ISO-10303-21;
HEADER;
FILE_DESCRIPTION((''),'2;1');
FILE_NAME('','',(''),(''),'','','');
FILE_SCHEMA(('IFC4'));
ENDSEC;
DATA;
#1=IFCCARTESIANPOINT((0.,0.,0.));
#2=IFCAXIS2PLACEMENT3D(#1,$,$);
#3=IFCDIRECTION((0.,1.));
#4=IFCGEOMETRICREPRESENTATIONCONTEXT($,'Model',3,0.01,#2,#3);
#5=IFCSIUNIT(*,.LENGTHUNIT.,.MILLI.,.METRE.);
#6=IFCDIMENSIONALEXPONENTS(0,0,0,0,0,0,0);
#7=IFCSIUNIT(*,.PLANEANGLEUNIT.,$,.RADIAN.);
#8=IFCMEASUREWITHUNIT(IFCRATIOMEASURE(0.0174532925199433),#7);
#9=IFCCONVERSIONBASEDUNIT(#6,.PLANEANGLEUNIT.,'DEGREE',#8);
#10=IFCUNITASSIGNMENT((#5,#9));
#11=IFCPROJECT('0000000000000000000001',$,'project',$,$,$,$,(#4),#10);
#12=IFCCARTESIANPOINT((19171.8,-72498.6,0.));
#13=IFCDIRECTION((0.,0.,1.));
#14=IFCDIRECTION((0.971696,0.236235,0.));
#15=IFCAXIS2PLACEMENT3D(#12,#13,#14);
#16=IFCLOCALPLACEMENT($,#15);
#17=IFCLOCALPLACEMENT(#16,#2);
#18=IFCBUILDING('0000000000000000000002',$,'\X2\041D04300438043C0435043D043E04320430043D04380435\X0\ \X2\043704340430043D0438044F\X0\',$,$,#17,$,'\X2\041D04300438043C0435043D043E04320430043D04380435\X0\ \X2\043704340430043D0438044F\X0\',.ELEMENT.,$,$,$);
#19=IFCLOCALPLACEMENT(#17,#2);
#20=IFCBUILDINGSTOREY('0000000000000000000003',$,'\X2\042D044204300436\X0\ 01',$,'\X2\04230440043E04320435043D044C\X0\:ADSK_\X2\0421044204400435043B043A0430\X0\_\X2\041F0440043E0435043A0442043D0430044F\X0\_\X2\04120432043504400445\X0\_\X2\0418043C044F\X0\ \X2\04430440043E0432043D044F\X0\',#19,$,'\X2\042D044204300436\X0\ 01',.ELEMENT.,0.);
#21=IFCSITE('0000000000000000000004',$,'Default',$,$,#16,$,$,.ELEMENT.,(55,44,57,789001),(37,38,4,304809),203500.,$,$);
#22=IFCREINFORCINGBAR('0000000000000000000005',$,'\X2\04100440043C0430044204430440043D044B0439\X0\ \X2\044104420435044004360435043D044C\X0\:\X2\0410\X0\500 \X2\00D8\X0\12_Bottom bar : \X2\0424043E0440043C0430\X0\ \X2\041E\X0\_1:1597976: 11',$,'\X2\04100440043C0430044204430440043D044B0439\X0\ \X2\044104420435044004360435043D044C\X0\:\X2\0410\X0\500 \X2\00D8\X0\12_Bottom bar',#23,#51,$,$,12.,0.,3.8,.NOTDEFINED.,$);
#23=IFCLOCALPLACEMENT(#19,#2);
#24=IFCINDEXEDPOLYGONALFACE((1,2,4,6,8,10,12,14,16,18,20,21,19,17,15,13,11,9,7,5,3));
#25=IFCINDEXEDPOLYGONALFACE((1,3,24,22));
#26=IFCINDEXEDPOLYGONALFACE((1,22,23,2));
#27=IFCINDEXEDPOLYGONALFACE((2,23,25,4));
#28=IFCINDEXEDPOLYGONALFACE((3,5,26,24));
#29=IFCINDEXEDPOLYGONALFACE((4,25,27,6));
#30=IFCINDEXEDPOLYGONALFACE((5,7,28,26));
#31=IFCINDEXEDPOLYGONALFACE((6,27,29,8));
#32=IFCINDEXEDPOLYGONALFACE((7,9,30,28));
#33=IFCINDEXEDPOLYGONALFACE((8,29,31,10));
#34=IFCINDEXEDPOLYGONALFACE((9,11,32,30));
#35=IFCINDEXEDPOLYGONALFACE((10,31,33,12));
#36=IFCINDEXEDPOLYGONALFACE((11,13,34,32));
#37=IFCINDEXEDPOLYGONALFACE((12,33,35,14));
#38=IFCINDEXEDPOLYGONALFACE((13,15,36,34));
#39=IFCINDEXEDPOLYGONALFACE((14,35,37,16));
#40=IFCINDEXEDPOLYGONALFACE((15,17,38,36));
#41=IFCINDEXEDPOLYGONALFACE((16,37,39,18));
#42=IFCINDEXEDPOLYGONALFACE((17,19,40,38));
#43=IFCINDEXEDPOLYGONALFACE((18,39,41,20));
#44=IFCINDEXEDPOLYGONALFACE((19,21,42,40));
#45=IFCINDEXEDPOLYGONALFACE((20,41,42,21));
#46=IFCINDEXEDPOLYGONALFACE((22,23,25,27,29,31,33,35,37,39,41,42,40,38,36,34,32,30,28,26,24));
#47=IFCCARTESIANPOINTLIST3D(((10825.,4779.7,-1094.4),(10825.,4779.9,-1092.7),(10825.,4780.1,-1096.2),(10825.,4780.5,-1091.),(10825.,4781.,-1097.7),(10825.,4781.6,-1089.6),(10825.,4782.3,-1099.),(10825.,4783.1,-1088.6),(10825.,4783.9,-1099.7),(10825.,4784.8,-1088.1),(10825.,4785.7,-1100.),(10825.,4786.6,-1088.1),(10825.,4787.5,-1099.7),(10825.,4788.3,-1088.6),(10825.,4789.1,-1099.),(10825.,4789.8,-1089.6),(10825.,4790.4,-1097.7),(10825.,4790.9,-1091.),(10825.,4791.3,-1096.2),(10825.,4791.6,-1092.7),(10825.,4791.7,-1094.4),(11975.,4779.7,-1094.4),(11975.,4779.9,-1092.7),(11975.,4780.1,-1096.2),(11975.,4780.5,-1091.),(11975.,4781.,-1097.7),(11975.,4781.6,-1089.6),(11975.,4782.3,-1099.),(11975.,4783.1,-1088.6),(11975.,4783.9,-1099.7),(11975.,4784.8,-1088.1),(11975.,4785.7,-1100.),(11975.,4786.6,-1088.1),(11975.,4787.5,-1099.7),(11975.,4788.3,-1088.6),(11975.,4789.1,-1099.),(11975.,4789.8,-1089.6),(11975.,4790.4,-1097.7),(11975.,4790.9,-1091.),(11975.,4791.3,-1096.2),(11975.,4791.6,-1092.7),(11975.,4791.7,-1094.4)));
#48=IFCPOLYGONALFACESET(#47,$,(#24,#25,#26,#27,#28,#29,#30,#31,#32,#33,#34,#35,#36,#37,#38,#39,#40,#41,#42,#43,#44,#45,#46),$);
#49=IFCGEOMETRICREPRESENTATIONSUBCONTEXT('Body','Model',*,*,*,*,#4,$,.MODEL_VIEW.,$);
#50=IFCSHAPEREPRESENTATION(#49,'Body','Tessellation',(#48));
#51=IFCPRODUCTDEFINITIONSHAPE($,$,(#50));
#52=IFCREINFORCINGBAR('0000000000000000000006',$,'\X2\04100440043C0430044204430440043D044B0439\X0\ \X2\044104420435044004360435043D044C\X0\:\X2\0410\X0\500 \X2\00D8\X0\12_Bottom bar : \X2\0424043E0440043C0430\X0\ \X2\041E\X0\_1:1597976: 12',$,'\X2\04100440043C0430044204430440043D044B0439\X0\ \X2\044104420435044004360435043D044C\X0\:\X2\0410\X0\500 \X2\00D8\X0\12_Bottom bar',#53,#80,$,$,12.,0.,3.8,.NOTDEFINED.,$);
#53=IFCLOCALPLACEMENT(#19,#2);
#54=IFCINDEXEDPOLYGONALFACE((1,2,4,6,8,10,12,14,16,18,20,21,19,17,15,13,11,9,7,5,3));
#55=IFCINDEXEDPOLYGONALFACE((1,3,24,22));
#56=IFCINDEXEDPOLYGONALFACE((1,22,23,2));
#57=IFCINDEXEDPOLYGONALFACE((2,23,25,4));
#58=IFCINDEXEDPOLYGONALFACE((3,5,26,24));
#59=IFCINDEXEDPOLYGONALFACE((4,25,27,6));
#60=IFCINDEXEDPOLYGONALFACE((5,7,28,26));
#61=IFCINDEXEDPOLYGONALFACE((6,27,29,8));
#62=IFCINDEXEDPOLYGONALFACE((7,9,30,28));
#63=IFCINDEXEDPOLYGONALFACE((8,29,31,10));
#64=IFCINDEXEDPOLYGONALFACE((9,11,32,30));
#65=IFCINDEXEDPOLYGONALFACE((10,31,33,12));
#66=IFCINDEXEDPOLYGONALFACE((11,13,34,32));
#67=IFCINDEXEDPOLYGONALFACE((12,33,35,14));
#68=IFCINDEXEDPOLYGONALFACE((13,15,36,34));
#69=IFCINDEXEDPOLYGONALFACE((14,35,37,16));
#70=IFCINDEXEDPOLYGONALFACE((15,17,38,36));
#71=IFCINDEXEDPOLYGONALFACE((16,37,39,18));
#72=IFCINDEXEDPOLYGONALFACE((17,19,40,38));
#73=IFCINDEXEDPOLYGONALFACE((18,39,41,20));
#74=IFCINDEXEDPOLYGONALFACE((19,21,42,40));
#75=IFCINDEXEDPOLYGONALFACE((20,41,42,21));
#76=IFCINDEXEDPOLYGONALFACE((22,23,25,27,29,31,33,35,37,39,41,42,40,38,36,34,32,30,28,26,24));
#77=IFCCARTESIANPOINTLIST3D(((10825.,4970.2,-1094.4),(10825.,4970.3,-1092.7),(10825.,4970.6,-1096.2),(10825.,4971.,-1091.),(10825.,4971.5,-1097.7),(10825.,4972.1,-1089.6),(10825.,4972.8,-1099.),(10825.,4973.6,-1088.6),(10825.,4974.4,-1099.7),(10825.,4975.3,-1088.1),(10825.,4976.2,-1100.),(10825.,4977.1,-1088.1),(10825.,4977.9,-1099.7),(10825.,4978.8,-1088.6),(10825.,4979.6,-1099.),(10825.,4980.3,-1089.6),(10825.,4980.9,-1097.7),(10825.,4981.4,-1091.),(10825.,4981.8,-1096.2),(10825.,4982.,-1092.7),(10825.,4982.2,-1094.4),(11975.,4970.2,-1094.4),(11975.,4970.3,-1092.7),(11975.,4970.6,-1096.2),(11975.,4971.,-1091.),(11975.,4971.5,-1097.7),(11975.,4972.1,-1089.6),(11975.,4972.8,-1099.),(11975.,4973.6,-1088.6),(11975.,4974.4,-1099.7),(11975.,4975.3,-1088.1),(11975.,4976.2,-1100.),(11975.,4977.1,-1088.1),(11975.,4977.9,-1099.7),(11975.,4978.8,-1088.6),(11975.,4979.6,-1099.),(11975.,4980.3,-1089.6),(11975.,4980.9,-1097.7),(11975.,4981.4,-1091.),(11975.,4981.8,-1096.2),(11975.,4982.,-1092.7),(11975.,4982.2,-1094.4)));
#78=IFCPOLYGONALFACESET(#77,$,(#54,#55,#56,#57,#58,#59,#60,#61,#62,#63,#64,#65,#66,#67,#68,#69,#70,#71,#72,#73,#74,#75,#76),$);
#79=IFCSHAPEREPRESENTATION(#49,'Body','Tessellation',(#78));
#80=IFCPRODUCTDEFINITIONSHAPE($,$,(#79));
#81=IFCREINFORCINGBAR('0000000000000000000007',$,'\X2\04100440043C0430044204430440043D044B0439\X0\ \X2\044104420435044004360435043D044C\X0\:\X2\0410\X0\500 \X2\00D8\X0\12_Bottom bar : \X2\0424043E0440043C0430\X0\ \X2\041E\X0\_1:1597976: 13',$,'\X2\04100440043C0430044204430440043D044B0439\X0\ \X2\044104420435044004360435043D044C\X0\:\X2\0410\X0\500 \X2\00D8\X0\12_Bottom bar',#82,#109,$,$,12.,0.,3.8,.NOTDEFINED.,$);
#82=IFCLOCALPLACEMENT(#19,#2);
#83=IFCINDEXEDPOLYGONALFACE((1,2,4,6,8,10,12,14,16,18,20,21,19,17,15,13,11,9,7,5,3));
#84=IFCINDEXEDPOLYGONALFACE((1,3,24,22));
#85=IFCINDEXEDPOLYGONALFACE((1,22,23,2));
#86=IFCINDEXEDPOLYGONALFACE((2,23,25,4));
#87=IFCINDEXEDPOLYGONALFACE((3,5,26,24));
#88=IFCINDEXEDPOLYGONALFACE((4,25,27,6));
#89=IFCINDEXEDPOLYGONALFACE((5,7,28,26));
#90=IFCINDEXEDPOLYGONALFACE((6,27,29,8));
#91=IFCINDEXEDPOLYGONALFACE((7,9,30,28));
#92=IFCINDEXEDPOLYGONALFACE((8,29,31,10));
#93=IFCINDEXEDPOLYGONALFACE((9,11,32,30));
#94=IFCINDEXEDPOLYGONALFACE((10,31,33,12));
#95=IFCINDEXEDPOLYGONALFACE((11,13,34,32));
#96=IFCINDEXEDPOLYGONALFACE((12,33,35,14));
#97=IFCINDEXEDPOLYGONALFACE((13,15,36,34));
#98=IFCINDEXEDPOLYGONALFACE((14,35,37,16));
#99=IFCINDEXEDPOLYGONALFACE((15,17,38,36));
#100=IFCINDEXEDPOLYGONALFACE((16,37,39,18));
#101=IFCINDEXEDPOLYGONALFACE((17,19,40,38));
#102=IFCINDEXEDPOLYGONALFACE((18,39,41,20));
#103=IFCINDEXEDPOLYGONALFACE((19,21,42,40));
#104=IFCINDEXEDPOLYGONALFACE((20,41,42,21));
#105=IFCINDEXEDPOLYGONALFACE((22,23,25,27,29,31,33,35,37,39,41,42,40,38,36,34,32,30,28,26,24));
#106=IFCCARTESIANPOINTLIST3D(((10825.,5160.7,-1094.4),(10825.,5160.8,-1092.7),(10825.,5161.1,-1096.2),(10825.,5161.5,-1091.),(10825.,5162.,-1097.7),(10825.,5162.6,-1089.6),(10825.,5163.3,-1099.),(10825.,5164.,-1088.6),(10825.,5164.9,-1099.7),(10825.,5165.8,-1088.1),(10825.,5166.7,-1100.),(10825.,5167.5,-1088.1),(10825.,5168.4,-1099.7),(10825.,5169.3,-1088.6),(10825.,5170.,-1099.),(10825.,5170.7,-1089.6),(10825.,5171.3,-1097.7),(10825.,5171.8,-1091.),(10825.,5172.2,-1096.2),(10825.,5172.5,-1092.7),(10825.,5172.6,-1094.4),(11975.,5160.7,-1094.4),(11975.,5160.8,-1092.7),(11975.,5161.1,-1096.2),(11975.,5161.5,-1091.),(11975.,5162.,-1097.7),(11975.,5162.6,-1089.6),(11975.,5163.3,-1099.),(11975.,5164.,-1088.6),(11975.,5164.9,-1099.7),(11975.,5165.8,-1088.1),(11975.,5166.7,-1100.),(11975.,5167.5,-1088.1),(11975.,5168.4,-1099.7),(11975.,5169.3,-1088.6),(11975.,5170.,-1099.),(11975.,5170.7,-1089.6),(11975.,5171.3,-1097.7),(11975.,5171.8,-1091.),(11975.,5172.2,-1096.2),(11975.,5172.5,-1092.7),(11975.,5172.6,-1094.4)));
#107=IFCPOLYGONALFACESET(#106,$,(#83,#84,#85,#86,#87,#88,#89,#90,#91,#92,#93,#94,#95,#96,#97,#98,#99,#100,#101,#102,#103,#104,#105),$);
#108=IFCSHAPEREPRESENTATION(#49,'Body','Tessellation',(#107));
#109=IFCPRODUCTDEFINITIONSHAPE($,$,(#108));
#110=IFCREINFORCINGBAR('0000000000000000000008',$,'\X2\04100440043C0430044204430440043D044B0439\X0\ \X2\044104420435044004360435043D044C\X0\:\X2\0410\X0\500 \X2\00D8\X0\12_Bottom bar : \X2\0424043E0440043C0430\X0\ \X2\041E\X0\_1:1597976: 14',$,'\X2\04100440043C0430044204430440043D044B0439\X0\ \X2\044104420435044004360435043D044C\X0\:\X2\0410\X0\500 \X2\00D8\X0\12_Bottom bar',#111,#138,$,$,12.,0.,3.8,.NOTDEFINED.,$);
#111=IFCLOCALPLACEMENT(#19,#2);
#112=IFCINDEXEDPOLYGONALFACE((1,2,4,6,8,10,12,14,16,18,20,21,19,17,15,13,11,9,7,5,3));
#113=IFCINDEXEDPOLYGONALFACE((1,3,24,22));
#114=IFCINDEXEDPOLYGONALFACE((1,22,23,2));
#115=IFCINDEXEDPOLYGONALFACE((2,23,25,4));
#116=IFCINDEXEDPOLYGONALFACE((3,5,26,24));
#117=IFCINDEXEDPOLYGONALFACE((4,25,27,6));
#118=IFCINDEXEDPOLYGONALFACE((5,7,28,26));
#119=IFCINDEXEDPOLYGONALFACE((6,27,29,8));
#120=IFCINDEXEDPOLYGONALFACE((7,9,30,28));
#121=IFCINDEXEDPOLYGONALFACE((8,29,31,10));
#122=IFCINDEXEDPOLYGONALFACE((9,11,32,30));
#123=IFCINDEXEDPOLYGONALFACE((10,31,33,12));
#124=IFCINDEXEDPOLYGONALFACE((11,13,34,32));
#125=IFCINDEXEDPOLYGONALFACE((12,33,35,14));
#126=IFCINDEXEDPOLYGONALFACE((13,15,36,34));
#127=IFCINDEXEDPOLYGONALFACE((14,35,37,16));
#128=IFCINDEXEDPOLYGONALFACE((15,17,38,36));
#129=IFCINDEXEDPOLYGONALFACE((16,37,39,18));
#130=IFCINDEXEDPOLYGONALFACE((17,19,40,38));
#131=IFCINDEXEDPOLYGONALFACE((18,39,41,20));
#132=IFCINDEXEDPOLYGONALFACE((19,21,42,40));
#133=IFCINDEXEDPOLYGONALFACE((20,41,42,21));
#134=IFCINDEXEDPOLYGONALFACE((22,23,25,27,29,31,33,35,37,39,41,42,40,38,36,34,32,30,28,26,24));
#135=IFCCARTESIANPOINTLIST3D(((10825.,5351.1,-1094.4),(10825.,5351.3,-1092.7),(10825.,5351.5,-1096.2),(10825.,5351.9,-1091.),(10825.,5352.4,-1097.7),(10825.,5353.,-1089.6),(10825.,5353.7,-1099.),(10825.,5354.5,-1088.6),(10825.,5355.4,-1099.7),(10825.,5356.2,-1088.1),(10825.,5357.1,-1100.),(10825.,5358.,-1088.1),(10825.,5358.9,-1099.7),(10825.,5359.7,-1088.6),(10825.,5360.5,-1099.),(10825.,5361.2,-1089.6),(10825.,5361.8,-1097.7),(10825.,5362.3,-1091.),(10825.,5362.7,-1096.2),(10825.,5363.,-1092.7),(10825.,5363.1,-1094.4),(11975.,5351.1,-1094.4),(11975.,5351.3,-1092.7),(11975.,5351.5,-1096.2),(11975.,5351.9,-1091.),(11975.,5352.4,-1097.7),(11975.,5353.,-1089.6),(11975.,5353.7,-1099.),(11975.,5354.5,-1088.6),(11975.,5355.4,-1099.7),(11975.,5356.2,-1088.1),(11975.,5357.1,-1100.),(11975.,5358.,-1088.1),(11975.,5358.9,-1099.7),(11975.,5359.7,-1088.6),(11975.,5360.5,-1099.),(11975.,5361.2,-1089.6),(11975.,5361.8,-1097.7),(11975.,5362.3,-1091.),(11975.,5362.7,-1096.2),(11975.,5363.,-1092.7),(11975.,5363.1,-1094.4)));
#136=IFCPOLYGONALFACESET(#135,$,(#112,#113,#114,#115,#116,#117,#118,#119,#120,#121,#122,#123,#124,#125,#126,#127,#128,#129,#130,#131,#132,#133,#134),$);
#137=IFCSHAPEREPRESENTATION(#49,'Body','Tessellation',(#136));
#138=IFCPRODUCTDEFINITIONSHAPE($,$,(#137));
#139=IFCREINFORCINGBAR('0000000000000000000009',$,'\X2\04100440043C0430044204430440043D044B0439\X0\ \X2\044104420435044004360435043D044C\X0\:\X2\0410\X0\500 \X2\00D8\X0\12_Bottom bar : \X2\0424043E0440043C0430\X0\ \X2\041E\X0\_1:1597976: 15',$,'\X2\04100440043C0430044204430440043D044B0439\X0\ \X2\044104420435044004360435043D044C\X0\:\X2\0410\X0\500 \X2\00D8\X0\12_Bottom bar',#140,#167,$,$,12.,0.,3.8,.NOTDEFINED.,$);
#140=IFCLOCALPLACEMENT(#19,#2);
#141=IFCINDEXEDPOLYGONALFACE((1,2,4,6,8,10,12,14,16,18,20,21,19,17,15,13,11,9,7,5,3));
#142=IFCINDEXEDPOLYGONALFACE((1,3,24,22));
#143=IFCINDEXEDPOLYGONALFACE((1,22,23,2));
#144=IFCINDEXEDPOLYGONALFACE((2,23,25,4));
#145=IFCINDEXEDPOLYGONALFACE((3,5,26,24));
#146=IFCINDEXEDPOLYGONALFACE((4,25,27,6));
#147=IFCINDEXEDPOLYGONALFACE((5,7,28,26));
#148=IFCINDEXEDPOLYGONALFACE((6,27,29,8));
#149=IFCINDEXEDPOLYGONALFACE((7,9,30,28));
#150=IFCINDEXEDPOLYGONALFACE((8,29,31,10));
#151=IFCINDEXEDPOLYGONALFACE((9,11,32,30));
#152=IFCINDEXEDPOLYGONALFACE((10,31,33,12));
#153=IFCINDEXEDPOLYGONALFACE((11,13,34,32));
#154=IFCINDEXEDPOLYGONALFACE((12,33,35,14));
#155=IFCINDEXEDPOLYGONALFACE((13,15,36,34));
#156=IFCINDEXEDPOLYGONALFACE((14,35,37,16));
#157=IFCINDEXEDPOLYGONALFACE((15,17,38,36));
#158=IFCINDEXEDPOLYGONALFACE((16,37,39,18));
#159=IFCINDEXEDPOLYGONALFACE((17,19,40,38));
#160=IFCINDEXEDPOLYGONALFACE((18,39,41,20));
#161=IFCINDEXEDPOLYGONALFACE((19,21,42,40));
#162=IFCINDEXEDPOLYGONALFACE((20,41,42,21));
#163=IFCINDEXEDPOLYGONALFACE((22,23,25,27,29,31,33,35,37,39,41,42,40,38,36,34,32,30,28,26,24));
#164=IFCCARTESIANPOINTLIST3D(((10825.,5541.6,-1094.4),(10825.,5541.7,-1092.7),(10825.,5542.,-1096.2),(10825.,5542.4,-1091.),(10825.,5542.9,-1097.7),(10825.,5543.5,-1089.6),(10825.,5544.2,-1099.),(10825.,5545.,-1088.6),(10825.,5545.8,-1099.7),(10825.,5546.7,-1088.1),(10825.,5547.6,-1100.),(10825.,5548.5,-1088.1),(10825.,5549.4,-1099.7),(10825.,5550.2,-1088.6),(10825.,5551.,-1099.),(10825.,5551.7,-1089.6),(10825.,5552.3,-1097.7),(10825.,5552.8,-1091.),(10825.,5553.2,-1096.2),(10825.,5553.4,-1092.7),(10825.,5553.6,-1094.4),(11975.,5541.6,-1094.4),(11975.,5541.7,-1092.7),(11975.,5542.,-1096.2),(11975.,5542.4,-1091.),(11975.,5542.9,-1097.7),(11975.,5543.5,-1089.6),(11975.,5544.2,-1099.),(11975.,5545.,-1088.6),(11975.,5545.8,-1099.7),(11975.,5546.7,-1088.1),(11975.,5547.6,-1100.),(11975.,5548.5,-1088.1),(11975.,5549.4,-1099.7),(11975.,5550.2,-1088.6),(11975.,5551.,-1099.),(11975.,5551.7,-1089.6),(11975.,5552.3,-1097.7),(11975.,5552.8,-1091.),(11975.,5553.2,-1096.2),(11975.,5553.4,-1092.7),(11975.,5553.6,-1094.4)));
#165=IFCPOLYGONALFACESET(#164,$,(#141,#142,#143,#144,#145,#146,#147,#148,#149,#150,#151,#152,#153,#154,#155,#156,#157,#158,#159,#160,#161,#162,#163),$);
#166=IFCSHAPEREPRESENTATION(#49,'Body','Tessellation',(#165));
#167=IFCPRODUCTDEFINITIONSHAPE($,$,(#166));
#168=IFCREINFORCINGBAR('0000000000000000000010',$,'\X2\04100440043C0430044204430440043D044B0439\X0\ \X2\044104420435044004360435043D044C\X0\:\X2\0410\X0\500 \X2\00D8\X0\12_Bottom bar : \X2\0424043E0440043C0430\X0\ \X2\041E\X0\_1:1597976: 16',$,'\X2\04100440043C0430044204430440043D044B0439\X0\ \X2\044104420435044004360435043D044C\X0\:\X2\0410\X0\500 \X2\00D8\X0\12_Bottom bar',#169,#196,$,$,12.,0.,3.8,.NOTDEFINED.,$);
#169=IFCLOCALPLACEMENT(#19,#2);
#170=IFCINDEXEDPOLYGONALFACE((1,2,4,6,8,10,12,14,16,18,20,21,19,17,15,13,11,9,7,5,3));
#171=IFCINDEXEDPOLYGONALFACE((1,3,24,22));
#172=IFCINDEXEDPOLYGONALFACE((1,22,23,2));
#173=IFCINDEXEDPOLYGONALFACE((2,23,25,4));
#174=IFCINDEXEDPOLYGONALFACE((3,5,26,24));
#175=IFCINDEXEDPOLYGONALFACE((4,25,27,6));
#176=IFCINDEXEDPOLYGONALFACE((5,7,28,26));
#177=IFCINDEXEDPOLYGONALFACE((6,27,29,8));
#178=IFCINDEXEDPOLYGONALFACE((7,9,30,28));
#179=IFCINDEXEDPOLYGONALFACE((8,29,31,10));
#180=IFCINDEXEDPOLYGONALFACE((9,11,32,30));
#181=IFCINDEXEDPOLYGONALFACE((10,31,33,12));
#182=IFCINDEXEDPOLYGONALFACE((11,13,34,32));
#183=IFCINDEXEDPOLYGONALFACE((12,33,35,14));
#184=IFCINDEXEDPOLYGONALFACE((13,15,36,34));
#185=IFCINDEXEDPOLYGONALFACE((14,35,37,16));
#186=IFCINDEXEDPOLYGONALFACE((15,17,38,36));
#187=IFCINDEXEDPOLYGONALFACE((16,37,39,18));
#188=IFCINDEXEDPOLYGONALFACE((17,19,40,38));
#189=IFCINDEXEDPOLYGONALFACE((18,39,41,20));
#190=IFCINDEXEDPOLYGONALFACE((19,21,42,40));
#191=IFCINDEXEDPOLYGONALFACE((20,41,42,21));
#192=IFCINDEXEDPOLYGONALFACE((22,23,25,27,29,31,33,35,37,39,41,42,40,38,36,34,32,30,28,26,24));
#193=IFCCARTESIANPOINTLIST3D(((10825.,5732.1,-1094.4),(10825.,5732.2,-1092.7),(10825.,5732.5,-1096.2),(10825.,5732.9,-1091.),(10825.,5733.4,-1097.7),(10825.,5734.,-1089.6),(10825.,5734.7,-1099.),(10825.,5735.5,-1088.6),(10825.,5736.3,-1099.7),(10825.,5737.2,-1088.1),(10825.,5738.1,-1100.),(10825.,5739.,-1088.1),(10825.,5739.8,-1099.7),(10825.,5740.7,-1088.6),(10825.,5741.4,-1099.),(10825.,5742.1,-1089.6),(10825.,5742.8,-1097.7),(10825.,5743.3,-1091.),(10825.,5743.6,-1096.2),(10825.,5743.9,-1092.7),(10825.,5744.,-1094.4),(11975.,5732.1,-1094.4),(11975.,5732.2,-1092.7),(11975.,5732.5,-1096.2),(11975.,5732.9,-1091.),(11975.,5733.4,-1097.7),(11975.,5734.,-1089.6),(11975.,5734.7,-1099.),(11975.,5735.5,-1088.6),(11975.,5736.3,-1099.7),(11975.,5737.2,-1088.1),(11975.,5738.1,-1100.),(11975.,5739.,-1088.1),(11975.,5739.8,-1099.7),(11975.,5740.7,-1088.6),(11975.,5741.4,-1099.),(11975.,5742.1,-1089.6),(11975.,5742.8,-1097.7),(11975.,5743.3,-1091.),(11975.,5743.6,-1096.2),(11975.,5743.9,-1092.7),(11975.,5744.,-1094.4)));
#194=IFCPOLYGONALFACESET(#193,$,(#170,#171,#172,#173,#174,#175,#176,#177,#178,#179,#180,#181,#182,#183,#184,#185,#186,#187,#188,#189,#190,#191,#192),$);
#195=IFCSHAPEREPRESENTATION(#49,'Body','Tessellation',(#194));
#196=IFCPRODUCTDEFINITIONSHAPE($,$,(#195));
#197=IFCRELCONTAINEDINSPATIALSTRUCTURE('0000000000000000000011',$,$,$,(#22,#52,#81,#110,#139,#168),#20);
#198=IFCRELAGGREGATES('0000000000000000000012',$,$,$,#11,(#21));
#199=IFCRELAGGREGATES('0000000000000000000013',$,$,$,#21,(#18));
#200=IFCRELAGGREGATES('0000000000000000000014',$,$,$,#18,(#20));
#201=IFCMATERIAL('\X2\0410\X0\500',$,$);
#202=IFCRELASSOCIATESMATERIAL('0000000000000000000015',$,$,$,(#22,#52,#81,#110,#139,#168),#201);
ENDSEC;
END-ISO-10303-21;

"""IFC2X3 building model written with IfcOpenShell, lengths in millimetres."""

from ifc_helpers import new_model, entity, si_unit, converted_unit, direction, frame, origin, place, context, subcontext, project, spatial, material, element, save


model = new_model("IFC2X3")

# Units and contexts
model_context = context("Model", 3, precision=0.01, world=origin(), true_north=direction((0.0, 1.0)))
body_context = subcontext(model_context, "Body", "Model", "MODEL_VIEW")
ifc_project = project(units=[si_unit("LENGTHUNIT", "METRE", prefix="MILLI"), converted_unit("PLANEANGLEUNIT", "DEGREE", entity("IfcRatioMeasure", 0.0174532925199433), si_unit("PLANEANGLEUNIT", "RADIAN"), dimensions=[0, 0, 0, 0, 0, 0, 0])], contexts=[model_context])

# Site, building, storey
site_placement = place(None, frame((19171.8, -72498.6, 0.0), z_axis=(0.0, 0.0, 1.0), x_axis=(0.971696, 0.236235, 0.0)))
site = spatial("IfcSite", under=ifc_project, at=site_placement, Name="Default", CompositionType="ELEMENT", RefLatitude=(55, 44, 57, 789001), RefLongitude=(37, 38, 4, 304809), RefElevation=203500.0)
building_placement = place(site_placement, origin())
building = spatial("IfcBuilding", under=site, at=building_placement, Name="Наименование здания", LongName="Наименование здания", CompositionType="ELEMENT")
storey_placement = place(building_placement, origin())
storey = spatial("IfcBuildingStorey", under=building, at=storey_placement, Name="Этаж 01", ObjectType="Уровень:ADSK_Стрелка_Проектная_Вверх_Имя уровня", LongName="Этаж 01", CompositionType="ELEMENT", Elevation=0.0)

# Reinforcing bars
ifc_material = material(Name="А500")
placement = place(storey_placement, origin())
element("IfcReinforcingBar", 1, at=placement, inside=storey, material=ifc_material, Name="Арматурный стержень:А500 Ø12_Bottom bar : Форма О_1:1597976: 11", ObjectType="Арматурный стержень:А500 Ø12_Bottom bar", BarLength=3.8, BarRole="NOTDEFINED", CrossSectionArea=0.0, NominalDiameter=12.0, context=body_context, shape_type="AdvancedSweptSolid", body=[
    entity("IfcSweptDiskSolid", entity("IfcCompositeCurve", [entity("IfcCompositeCurveSegment", "CONTINUOUS", True, entity("IfcPolyline", [entity("IfcCartesianPoint", [11975.0, 4785.7, -1094.0]), entity("IfcCartesianPoint", [10825.0, 4785.7, -1094.0])]))], False), 6.0, None, 0.0, 1.0),
])
element("IfcReinforcingBar", 2, at=placement, inside=storey, material=ifc_material, Name="Арматурный стержень:А500 Ø12_Bottom bar : Форма О_1:1597976: 12", ObjectType="Арматурный стержень:А500 Ø12_Bottom bar", BarLength=3.8, BarRole="NOTDEFINED", CrossSectionArea=0.0, NominalDiameter=12.0, context=body_context, shape_type="AdvancedSweptSolid", body=[
    entity("IfcSweptDiskSolid", entity("IfcCompositeCurve", [entity("IfcCompositeCurveSegment", "CONTINUOUS", True, entity("IfcPolyline", [entity("IfcCartesianPoint", [11975.0, 4976.2, -1094.0]), entity("IfcCartesianPoint", [10825.0, 4976.2, -1094.0])]))], False), 6.0, None, 0.0, 1.0),
])
element("IfcReinforcingBar", 3, at=placement, inside=storey, material=ifc_material, Name="Арматурный стержень:А500 Ø12_Bottom bar : Форма О_1:1597976: 13", ObjectType="Арматурный стержень:А500 Ø12_Bottom bar", BarLength=3.8, BarRole="NOTDEFINED", CrossSectionArea=0.0, NominalDiameter=12.0, context=body_context, shape_type="AdvancedSweptSolid", body=[
    entity("IfcSweptDiskSolid", entity("IfcCompositeCurve", [entity("IfcCompositeCurveSegment", "CONTINUOUS", True, entity("IfcPolyline", [entity("IfcCartesianPoint", [11975.0, 5166.6, -1094.0]), entity("IfcCartesianPoint", [10825.0, 5166.6, -1094.0])]))], False), 6.0, None, 0.0, 1.0),
])
element("IfcReinforcingBar", 4, at=placement, inside=storey, material=ifc_material, Name="Арматурный стержень:А500 Ø12_Bottom bar : Форма О_1:1597976: 14", ObjectType="Арматурный стержень:А500 Ø12_Bottom bar", BarLength=3.8, BarRole="NOTDEFINED", CrossSectionArea=0.0, NominalDiameter=12.0, context=body_context, shape_type="AdvancedSweptSolid", body=[
    entity("IfcSweptDiskSolid", entity("IfcCompositeCurve", [entity("IfcCompositeCurveSegment", "CONTINUOUS", True, entity("IfcPolyline", [entity("IfcCartesianPoint", [11975.0, 5357.1, -1094.0]), entity("IfcCartesianPoint", [10825.0, 5357.1, -1094.0])]))], False), 6.0, None, 0.0, 1.0),
])
element("IfcReinforcingBar", 5, at=placement, inside=storey, material=ifc_material, Name="Арматурный стержень:А500 Ø12_Bottom bar : Форма О_1:1597976: 15", ObjectType="Арматурный стержень:А500 Ø12_Bottom bar", BarLength=3.8, BarRole="NOTDEFINED", CrossSectionArea=0.0, NominalDiameter=12.0, context=body_context, shape_type="AdvancedSweptSolid", body=[
    entity("IfcSweptDiskSolid", entity("IfcCompositeCurve", [entity("IfcCompositeCurveSegment", "CONTINUOUS", True, entity("IfcPolyline", [entity("IfcCartesianPoint", [11975.0, 5547.6, -1094.0]), entity("IfcCartesianPoint", [10825.0, 5547.6, -1094.0])]))], False), 6.0, None, 0.0, 1.0),
])
element("IfcReinforcingBar", 6, at=placement, inside=storey, material=ifc_material, Name="Арматурный стержень:А500 Ø12_Bottom bar : Форма О_1:1597976: 16", ObjectType="Арматурный стержень:А500 Ø12_Bottom bar", BarLength=3.8, BarRole="NOTDEFINED", CrossSectionArea=0.0, NominalDiameter=12.0, context=body_context, shape_type="AdvancedSweptSolid", body=[
    entity("IfcSweptDiskSolid", entity("IfcCompositeCurve", [entity("IfcCompositeCurveSegment", "CONTINUOUS", True, entity("IfcPolyline", [entity("IfcCartesianPoint", [11975.0, 5738.1, -1094.0]), entity("IfcCartesianPoint", [10825.0, 5738.1, -1094.0])]))], False), 6.0, None, 0.0, 1.0),
])

save(model, "model.ifc")
